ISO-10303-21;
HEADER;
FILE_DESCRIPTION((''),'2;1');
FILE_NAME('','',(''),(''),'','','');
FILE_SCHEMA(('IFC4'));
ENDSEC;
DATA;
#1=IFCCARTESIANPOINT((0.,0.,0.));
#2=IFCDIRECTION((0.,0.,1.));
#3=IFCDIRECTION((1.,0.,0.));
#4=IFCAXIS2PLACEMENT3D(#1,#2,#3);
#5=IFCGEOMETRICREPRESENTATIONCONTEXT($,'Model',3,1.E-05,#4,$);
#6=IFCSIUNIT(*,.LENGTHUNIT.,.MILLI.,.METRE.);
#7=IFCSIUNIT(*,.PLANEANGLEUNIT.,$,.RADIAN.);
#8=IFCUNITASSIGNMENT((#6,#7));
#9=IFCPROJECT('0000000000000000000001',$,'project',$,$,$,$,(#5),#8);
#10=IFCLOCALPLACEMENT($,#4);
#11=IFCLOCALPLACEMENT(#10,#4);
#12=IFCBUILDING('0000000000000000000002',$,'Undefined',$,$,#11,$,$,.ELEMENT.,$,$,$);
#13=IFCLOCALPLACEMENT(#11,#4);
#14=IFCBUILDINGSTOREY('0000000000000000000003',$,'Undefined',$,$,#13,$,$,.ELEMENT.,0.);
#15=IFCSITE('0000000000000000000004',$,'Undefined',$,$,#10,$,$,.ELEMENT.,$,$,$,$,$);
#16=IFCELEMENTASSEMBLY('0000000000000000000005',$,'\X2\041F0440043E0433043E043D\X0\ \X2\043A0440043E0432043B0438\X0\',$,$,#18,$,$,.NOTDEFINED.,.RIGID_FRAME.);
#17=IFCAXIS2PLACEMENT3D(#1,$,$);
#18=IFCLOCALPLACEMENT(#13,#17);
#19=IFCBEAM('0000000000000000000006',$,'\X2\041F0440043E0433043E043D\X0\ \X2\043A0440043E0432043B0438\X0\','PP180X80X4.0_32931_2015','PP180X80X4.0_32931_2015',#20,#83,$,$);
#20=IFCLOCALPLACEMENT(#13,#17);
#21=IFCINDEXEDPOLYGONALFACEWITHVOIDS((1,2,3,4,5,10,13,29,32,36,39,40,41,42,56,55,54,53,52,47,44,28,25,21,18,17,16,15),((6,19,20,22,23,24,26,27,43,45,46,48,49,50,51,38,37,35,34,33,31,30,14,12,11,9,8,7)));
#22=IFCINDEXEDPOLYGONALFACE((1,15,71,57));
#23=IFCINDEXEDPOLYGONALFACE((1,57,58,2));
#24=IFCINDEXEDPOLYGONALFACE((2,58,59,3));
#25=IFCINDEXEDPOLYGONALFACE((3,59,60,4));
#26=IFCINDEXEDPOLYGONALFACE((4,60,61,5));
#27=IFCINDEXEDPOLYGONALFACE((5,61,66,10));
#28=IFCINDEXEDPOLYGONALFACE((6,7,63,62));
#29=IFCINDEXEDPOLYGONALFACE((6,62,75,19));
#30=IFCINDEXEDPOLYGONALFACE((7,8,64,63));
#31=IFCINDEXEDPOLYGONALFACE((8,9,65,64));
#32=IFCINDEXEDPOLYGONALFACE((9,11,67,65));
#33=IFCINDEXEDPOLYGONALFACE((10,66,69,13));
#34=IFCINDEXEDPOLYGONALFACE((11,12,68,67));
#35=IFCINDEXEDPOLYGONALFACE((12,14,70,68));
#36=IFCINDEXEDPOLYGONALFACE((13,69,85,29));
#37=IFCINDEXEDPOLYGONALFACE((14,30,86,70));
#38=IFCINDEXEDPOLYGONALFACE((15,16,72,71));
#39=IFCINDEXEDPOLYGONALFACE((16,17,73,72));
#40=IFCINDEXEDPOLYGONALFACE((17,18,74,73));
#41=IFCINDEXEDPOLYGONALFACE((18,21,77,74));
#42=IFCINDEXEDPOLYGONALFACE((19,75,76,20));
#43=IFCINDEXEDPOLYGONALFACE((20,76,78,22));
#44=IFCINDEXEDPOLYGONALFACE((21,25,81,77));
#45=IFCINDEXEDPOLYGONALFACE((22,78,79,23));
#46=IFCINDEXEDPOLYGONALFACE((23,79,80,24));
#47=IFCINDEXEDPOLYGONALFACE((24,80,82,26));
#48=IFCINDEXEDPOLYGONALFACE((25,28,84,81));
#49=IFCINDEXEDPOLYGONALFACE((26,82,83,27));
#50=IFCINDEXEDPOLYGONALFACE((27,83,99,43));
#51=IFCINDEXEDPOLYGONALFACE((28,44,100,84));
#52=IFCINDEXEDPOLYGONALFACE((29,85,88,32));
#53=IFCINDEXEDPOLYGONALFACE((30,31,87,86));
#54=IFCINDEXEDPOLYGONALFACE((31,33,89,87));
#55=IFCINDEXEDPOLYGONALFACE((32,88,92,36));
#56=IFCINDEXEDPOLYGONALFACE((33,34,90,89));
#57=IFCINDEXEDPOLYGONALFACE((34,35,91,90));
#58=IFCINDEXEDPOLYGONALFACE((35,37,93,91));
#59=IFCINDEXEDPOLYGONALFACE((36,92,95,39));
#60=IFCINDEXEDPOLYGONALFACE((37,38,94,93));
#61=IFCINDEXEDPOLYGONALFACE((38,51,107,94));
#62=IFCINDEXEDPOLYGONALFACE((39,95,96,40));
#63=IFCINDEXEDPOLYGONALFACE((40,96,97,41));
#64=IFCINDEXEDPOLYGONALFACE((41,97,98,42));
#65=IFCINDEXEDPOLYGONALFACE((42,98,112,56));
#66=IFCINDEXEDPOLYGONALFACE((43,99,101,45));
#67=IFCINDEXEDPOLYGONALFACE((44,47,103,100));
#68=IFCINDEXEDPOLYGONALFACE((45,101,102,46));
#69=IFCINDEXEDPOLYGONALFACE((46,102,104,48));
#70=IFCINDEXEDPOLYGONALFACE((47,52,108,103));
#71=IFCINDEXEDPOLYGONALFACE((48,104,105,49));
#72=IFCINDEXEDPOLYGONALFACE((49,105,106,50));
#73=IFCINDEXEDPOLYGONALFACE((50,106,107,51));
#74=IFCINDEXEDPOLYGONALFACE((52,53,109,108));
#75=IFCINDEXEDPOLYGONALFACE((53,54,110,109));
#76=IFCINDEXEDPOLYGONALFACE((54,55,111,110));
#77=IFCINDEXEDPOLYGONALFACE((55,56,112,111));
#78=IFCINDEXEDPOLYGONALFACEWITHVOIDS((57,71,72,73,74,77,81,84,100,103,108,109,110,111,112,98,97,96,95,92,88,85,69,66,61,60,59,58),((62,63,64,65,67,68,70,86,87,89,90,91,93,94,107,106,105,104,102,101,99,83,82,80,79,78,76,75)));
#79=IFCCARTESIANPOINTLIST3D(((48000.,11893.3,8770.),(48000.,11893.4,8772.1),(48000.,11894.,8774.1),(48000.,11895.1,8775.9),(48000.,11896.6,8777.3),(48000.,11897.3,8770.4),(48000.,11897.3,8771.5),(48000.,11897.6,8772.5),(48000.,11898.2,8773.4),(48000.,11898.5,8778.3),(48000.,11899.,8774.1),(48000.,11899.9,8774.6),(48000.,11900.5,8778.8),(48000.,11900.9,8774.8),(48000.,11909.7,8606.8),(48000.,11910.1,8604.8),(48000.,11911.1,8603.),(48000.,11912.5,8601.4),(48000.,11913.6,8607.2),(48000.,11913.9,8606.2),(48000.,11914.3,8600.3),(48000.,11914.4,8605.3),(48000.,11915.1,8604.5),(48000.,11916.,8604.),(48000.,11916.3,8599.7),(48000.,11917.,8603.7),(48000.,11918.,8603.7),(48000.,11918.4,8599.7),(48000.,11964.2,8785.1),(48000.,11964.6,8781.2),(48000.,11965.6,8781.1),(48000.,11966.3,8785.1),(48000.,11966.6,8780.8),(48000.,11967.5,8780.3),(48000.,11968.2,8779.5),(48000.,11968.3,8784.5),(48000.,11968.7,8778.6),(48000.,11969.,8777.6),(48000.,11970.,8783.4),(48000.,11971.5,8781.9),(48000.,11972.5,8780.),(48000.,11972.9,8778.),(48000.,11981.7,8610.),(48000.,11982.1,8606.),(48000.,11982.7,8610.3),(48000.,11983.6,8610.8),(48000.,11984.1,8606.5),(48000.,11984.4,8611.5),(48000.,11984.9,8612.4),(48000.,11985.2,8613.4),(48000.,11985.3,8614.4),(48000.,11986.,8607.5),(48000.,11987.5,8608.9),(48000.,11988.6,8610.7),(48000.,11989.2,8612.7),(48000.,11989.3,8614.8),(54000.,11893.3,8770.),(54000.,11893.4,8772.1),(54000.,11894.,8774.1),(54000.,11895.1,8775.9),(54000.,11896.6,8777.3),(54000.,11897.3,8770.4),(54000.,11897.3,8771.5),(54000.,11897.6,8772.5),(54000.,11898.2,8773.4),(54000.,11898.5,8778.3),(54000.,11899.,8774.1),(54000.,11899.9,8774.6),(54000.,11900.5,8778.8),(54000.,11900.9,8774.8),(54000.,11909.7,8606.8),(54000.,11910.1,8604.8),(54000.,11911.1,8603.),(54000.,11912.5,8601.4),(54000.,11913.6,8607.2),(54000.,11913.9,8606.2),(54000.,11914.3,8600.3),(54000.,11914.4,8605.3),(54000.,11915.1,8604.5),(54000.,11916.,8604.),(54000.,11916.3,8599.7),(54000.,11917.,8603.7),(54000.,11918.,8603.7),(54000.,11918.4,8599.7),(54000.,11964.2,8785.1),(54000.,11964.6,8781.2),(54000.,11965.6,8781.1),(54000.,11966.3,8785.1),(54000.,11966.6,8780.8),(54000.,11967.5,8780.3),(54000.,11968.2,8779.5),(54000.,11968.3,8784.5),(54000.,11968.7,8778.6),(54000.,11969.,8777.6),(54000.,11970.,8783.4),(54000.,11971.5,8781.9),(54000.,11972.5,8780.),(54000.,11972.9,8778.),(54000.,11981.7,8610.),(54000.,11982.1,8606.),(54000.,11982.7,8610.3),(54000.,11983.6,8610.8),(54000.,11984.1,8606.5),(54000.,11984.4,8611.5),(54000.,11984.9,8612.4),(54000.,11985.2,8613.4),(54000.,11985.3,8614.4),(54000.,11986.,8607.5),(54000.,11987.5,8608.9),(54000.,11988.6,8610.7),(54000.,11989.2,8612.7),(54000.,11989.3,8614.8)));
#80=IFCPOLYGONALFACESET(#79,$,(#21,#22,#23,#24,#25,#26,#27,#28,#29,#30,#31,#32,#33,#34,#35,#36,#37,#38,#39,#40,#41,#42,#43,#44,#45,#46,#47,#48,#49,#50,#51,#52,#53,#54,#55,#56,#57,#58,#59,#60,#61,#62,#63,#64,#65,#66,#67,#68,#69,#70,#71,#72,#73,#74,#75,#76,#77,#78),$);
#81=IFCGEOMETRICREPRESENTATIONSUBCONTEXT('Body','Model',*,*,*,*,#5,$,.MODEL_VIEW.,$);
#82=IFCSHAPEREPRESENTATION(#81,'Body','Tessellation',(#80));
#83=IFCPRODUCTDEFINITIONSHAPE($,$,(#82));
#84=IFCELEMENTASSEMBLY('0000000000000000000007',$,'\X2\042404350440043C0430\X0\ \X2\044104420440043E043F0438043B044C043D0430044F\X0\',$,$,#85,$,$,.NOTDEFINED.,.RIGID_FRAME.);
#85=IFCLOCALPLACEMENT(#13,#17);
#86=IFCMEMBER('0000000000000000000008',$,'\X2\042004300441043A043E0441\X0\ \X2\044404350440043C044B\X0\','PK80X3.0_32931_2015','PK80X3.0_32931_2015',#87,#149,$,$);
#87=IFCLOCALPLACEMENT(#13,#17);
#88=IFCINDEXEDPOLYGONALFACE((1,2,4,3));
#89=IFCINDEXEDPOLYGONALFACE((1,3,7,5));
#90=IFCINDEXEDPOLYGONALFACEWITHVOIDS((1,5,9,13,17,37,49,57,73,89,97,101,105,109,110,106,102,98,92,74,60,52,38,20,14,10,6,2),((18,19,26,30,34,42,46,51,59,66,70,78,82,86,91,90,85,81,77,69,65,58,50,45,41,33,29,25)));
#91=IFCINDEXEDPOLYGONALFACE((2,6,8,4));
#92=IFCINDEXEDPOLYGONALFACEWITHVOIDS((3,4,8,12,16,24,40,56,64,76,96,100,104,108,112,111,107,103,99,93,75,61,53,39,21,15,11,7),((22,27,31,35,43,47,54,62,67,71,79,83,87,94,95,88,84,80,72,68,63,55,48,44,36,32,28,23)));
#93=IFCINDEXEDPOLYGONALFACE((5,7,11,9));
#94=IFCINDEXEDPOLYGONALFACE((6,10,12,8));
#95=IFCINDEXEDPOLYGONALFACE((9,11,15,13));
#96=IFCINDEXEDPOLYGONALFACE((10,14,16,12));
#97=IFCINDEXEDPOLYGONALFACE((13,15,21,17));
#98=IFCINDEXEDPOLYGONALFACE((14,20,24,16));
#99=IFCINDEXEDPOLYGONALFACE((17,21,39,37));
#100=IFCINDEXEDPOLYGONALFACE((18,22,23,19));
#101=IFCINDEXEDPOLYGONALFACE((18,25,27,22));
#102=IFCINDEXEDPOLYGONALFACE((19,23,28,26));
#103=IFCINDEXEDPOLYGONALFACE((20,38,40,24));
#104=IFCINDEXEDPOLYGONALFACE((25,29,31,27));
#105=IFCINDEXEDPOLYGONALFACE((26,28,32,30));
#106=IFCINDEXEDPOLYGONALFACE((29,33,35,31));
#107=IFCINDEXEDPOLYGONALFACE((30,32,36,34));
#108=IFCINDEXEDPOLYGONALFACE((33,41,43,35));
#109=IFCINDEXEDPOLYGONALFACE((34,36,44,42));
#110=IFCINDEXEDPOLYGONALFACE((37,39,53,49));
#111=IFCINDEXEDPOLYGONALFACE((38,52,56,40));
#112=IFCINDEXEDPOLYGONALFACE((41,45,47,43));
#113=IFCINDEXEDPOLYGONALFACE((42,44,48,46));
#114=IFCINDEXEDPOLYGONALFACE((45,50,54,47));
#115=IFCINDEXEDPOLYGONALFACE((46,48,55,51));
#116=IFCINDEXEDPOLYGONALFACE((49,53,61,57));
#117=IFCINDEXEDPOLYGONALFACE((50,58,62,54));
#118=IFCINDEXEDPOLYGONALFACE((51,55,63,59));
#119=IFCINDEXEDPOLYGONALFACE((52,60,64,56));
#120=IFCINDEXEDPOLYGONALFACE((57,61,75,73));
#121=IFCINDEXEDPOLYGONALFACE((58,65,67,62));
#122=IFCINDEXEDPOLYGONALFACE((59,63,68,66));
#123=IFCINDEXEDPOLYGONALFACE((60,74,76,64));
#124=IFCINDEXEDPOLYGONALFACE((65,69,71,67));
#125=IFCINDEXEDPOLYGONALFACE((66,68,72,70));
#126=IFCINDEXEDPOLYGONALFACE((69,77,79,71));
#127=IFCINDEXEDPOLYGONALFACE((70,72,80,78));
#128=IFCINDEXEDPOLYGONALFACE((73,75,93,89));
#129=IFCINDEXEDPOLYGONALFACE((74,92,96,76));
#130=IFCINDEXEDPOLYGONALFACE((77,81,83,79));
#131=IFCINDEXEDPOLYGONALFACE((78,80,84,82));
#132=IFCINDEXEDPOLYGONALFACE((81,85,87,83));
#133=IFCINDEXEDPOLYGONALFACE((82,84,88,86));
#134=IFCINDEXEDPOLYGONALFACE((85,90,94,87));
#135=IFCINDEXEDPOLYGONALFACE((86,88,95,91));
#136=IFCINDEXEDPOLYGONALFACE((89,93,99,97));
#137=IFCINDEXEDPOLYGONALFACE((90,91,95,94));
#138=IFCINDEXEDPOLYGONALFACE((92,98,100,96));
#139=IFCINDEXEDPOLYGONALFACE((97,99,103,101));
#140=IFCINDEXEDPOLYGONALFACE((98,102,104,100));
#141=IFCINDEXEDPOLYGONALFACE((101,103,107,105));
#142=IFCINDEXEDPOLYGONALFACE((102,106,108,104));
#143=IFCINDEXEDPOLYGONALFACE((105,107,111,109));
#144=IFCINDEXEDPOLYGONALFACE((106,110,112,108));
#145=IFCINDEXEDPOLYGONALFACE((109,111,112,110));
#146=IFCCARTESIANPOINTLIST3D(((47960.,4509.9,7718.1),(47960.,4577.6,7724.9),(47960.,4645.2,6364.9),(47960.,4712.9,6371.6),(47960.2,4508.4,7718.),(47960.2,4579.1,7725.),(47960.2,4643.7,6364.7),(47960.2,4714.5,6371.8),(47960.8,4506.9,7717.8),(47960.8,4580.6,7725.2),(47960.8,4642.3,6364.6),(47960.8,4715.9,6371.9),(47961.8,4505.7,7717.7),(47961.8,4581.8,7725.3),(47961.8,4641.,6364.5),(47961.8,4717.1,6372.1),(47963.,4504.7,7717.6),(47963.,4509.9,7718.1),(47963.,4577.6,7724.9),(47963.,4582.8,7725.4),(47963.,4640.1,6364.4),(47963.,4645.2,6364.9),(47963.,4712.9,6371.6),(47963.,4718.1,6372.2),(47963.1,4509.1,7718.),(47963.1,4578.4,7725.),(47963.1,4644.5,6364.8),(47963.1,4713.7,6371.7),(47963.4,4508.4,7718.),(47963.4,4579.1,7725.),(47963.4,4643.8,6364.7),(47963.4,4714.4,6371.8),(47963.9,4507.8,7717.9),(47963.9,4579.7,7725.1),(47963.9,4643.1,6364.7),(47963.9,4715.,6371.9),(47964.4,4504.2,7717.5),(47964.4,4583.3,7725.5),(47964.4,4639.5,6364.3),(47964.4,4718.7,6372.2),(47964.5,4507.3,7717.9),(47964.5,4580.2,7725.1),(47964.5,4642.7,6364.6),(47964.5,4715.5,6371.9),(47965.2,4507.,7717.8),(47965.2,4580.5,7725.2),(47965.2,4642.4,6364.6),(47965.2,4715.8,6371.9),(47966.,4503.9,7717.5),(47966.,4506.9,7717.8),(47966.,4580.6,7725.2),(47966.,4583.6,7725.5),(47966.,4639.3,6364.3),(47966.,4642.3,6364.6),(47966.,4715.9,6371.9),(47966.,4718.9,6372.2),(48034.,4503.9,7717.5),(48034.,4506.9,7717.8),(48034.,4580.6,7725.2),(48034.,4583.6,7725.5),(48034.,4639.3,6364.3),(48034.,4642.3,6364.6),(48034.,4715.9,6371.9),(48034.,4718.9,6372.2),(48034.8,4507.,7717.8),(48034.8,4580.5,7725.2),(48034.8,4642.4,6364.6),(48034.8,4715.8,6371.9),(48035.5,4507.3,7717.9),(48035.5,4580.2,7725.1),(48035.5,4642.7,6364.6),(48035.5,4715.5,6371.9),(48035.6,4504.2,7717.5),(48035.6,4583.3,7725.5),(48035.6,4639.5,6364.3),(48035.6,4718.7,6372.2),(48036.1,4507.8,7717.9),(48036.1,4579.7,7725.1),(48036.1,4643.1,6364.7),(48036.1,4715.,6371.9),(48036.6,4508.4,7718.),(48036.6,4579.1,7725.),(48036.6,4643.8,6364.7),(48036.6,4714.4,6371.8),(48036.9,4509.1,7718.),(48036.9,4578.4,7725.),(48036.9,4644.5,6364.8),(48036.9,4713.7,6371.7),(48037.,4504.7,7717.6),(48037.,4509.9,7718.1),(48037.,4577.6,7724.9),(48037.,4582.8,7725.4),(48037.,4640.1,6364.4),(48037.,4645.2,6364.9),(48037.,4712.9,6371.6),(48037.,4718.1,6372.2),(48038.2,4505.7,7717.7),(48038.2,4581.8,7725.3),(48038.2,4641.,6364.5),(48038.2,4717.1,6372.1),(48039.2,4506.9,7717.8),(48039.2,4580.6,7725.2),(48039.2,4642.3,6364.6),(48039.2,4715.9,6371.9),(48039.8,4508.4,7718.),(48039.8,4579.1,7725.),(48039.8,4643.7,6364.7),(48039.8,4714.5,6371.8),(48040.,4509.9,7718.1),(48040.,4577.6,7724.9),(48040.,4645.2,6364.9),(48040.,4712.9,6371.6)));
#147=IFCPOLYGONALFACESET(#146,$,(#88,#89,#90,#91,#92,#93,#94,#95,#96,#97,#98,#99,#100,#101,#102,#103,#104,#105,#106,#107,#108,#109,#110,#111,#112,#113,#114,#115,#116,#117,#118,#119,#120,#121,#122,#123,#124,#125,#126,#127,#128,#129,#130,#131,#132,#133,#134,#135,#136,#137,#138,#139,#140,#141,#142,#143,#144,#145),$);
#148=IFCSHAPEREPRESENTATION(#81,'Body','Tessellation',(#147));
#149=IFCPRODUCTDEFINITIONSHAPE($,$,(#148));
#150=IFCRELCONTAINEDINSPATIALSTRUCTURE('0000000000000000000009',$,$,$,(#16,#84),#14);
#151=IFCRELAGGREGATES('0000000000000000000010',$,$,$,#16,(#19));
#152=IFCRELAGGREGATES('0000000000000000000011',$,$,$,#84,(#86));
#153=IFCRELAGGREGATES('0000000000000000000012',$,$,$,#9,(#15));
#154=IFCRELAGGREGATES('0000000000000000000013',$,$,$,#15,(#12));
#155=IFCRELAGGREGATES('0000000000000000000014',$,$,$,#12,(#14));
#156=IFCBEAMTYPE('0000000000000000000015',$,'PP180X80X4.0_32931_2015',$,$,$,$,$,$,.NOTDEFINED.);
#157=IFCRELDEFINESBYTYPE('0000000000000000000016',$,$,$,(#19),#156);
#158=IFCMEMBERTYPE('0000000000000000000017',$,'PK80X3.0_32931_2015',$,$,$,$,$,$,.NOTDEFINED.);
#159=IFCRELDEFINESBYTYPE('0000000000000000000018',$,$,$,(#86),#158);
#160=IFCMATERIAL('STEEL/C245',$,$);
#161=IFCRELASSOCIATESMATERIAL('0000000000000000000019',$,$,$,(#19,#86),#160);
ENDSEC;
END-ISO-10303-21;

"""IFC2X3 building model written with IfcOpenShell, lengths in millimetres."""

from ifc_helpers import new_model, si_unit, frame, origin_with_axes, origin_2d_with_axis, place, context, subcontext, project, spatial, hollow_rectangle, extrude, material, type_object, element, aggregate, save


model = new_model("IFC2X3")

# Units and contexts
model_context = context("Model", 3, precision=1e-05, world=origin_with_axes())
body_context = subcontext(model_context, "Body", "Model", "MODEL_VIEW")
ifc_project = project(units=[si_unit("LENGTHUNIT", "METRE", prefix="MILLI"), si_unit("PLANEANGLEUNIT", "RADIAN")], contexts=[model_context])

# Site, building, storey
site_placement = place(None, origin_with_axes())
site = spatial("IfcSite", under=ifc_project, at=site_placement, Name="Undefined", CompositionType="ELEMENT")
building_placement = place(site_placement, origin_with_axes())
building = spatial("IfcBuilding", under=site, at=building_placement, Name="Undefined", CompositionType="ELEMENT")
storey_placement = place(building_placement, origin_with_axes())
storey = spatial("IfcBuildingStorey", under=building, at=storey_placement, Name="Undefined", CompositionType="ELEMENT", Elevation=0.0)

# Shared definitions
ifc_material_1 = material(Name="STEEL/C245")

# Element assembly, beam
assembly_1_placement = place(storey_placement, origin_with_axes())
assembly_1 = element("IfcElementAssembly", 1, at=assembly_1_placement, inside=storey, Name="Прогон кровли", AssemblyPlace="NOTDEFINED", PredefinedType="RIGID_FRAME")
beam_type_1 = type_object("IfcBeamType", Name="PP180X80X4.0_32931_2015", PredefinedType="NOTDEFINED")
beam_1_placement = place(assembly_1_placement, frame((48000.0, 11941.3, 8692.4), z_axis=(0.0, -0.099504, 0.995037), x_axis=(1.0, 0.0, 0.0)))
beam_1 = element("IfcBeam", 2, at=beam_1_placement, type_object=beam_type_1, material=ifc_material_1, Name="Прогон кровли", Description="PP180X80X4.0_32931_2015", ObjectType="PP180X80X4.0_32931_2015", context=body_context, shape_type="SweptSolid", body=[
    extrude(hollow_rectangle(XDim=80.0, YDim=180.0, WallThickness=4.0, InnerFilletRadius=4.0, OuterFilletRadius=8.0, at=origin_2d_with_axis()), frame((6000.0, 0.0, 0.0), z_axis=(-1.0, 0.0, 0.0), x_axis=(0.0, -1.0, 0.0)), (0.0, 0.0, 1.0), 6000.0),
])
aggregate(assembly_1, [beam_1])

# Element assembly, member
assembly_2_placement = place(storey_placement, origin_with_axes())
assembly_2 = element("IfcElementAssembly", 3, at=assembly_2_placement, inside=storey, Name="Ферма стропильная", AssemblyPlace="NOTDEFINED", PredefinedType="RIGID_FRAME")
member_type_1 = type_object("IfcMemberType", Name="PK80X3.0_32931_2015", PredefinedType="NOTDEFINED")
member_1_placement = place(assembly_2_placement, frame((48000.0, 4543.8, 7721.5), z_axis=(0.0, 0.995037, 0.099504), x_axis=(0.0, 0.099504, -0.995037)))
member_1 = element("IfcMember", 4, at=member_1_placement, type_object=member_type_1, material=ifc_material_1, Name="Раскос фермы", Description="PK80X3.0_32931_2015", ObjectType="PK80X3.0_32931_2015", context=body_context, shape_type="SweptSolid", body=[
    extrude(hollow_rectangle(XDim=80.0, YDim=80.0, WallThickness=3.0, InnerFilletRadius=3.0, OuterFilletRadius=6.0, at=origin_2d_with_axis()), frame((1360.0, 0.0, 0.0), z_axis=(-1.0, 0.0, 0.0), x_axis=(0.0, -1.0, 0.0)), (0.0, 0.0, 1.0), 1360.0),
])
aggregate(assembly_2, [member_1])

save(model, "model.ifc")
